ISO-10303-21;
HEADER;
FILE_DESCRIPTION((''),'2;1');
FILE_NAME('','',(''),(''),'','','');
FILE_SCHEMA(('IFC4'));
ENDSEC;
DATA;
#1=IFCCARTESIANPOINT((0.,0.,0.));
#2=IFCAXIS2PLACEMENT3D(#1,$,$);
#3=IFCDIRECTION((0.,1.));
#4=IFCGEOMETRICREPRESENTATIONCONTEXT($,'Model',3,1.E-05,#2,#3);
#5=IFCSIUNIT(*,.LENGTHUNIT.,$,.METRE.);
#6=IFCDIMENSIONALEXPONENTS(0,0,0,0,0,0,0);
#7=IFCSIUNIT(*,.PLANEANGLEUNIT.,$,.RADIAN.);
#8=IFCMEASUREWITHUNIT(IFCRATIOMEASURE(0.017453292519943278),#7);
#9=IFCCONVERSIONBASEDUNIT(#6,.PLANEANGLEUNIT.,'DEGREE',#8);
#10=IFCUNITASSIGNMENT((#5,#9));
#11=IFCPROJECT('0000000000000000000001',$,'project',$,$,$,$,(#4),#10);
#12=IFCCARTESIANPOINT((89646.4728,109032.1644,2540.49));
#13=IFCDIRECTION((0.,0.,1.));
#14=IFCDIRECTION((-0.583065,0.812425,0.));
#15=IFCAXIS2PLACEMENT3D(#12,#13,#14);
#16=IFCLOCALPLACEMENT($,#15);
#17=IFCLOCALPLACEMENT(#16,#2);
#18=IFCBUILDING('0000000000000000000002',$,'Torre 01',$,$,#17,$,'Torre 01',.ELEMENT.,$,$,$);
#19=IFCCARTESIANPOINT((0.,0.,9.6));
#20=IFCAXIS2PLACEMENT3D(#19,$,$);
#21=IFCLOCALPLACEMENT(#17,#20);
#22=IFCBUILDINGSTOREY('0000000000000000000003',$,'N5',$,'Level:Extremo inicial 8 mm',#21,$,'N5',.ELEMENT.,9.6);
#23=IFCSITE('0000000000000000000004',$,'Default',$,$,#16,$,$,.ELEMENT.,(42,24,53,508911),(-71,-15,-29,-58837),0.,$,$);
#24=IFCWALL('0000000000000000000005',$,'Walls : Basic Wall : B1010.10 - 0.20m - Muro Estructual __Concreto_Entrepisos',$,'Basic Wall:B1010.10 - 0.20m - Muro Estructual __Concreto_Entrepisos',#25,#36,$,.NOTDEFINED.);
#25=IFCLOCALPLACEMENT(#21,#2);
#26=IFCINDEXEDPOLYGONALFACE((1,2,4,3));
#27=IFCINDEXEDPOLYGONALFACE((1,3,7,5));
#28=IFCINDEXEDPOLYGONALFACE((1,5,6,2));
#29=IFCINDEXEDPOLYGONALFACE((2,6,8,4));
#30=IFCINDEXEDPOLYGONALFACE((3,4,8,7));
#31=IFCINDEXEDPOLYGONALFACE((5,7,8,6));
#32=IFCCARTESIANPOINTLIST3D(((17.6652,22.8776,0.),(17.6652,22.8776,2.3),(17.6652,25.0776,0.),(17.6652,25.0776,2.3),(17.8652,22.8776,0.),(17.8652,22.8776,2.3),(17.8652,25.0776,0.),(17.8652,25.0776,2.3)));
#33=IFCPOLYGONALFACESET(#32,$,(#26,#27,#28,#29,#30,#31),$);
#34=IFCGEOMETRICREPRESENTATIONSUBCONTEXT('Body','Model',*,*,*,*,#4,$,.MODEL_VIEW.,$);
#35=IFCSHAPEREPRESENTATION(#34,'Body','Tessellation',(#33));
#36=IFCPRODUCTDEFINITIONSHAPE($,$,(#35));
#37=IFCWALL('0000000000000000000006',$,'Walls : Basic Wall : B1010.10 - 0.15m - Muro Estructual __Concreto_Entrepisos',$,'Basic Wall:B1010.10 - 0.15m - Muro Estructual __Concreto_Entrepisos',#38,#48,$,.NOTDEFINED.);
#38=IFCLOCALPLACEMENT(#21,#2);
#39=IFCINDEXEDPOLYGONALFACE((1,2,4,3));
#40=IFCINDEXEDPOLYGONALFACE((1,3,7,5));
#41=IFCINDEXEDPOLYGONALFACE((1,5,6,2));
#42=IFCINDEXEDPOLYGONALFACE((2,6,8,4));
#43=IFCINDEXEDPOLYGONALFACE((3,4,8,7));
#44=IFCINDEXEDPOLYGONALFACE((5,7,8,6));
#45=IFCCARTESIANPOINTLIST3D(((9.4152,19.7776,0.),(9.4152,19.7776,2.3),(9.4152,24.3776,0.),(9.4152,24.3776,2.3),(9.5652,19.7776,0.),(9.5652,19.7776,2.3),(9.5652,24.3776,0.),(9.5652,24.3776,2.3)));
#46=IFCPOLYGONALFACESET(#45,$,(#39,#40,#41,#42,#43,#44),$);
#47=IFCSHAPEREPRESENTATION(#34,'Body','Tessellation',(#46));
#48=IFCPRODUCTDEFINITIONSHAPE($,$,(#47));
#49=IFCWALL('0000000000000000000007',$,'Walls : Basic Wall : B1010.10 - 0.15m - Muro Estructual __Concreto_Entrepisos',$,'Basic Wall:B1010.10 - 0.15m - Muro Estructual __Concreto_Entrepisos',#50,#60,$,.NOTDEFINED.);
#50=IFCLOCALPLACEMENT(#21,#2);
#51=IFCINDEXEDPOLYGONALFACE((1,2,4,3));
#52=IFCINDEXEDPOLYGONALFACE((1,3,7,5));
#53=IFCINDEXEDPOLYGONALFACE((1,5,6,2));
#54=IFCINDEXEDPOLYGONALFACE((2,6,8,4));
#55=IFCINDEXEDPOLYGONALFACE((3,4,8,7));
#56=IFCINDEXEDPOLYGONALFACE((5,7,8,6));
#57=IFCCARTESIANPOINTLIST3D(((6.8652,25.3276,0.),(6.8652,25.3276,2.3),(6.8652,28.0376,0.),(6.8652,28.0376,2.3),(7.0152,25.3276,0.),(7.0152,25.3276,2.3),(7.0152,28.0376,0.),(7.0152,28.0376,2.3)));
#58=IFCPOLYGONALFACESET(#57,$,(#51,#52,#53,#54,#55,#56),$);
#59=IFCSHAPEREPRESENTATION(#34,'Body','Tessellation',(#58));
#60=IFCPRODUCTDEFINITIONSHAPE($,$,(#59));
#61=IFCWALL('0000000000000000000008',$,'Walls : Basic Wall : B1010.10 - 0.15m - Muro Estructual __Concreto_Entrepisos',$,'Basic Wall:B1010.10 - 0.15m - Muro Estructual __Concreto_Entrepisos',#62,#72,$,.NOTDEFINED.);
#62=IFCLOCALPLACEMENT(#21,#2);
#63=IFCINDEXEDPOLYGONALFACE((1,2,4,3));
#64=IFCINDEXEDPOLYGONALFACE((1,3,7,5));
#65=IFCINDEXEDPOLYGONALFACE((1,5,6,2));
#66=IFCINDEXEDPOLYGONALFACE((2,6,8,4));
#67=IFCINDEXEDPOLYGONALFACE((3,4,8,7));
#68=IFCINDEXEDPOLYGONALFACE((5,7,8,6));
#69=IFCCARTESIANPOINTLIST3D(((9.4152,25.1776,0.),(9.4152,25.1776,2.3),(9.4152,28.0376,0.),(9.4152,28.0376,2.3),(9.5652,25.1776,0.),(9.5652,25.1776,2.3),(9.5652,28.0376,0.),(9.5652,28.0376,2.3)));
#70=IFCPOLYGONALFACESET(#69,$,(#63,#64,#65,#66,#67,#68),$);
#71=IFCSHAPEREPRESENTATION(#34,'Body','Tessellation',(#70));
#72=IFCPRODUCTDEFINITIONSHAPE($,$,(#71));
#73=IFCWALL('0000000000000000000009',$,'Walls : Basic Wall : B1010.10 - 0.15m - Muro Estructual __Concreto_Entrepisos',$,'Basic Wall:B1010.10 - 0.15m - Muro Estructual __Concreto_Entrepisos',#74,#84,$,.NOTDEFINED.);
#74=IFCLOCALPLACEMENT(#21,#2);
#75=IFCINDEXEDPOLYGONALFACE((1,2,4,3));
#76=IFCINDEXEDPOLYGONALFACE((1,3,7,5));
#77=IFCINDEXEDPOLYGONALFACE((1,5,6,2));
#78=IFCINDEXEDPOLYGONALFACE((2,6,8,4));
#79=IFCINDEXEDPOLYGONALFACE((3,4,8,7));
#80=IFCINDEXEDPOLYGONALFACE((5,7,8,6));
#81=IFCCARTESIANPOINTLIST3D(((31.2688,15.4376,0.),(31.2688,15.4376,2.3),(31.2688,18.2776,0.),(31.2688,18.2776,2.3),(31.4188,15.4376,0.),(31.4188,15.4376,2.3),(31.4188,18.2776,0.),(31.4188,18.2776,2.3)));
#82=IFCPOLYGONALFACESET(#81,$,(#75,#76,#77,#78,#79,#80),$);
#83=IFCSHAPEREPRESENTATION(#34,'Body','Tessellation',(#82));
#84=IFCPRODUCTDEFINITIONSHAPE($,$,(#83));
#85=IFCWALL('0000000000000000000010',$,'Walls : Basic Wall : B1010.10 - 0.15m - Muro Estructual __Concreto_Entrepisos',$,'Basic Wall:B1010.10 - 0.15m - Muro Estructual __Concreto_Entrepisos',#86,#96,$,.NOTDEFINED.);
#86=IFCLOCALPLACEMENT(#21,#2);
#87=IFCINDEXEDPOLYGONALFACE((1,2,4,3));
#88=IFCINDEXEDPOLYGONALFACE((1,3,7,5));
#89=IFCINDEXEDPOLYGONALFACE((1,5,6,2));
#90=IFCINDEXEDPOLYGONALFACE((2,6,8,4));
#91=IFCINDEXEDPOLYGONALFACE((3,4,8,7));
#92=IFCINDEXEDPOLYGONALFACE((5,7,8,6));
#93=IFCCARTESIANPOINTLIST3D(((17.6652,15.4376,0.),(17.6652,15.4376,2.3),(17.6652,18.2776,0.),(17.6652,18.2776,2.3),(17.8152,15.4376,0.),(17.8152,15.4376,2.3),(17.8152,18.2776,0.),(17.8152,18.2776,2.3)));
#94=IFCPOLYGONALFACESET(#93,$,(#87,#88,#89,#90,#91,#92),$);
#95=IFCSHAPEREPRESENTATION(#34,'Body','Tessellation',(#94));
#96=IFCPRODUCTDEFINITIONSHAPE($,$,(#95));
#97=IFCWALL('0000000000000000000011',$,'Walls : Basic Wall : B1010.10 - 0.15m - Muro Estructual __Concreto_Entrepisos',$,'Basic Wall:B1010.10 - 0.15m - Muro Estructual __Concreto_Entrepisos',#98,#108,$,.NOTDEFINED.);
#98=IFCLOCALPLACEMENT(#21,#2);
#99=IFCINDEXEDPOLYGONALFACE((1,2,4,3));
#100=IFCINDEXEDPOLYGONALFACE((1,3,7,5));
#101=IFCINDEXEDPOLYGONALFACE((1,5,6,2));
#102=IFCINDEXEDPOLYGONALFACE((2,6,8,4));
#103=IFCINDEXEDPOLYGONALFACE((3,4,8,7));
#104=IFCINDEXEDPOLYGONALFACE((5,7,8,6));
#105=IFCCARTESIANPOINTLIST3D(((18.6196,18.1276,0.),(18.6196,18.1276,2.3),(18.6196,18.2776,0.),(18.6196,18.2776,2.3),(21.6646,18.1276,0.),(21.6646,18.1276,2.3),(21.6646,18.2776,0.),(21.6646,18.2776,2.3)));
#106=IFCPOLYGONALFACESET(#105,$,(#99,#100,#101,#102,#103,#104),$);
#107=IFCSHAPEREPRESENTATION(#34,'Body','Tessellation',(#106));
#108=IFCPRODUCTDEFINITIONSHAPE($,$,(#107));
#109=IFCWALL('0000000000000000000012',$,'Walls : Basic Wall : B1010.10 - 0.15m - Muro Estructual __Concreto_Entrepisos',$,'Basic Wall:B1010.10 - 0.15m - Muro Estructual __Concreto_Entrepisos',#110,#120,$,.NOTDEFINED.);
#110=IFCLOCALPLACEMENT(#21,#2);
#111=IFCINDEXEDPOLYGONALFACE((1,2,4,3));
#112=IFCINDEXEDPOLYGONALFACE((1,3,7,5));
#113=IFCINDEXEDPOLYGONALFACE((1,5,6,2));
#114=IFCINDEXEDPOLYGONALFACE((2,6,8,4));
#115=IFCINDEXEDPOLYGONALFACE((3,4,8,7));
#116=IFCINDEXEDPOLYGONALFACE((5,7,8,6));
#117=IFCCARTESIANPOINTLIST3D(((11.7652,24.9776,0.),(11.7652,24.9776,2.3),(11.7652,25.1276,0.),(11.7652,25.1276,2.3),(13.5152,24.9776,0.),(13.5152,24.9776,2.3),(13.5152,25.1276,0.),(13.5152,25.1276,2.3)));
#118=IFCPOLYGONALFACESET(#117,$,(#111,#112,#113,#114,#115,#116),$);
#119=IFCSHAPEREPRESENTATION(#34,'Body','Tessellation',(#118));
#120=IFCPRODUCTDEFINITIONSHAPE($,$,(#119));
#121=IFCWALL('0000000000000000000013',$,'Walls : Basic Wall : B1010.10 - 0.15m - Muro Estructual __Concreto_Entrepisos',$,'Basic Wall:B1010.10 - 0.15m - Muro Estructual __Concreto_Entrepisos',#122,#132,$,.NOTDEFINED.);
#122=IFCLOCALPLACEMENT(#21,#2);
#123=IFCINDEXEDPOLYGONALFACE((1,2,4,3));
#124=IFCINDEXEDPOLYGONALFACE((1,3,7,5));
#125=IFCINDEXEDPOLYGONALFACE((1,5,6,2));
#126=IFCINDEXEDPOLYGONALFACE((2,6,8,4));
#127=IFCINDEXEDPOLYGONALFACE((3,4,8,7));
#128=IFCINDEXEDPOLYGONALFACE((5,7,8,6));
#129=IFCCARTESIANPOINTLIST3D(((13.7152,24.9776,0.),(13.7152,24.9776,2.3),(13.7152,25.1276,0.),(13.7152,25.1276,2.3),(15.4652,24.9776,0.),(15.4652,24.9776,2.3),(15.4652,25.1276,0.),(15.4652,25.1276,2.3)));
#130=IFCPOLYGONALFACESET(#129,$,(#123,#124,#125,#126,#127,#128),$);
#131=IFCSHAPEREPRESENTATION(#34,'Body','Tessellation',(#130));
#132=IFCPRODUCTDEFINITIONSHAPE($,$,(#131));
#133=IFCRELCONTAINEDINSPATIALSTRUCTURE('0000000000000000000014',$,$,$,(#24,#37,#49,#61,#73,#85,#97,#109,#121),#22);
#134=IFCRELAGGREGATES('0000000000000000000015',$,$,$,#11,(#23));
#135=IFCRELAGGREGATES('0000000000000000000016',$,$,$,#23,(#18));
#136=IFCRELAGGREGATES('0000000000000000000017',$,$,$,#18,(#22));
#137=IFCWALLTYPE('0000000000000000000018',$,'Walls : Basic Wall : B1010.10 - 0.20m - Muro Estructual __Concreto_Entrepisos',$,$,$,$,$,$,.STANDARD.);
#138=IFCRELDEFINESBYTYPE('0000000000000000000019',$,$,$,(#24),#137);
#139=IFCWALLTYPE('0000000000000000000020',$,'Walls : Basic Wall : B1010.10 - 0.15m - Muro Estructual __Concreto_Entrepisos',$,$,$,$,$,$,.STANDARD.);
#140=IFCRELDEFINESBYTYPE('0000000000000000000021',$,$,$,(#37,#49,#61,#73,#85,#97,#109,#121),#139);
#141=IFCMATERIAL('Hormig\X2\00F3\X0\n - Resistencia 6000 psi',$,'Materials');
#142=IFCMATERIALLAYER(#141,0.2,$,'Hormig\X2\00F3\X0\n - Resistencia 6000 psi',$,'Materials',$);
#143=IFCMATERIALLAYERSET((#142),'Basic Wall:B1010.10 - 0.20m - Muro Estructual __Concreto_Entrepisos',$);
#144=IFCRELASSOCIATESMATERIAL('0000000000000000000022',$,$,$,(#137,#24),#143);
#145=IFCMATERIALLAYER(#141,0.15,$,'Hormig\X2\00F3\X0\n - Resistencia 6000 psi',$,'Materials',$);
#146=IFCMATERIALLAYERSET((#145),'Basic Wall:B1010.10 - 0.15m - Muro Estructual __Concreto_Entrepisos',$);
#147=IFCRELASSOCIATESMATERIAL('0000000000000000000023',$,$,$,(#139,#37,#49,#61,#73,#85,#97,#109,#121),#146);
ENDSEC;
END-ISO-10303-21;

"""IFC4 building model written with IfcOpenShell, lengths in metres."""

from ifc_helpers import new_model, entity, si_unit, converted_unit, direction, frame, frame_2d, origin, place, context, subcontext, project, spatial, rectangle, extrude, material, layer, layer_set, layer_usage, type_object, element, save


model = new_model("IFC4")

# Units and contexts
model_context = context("Model", 3, precision=1e-05, world=origin(), true_north=direction((0.0, 1.0)))
body_context = subcontext(model_context, "Body", "Model", "MODEL_VIEW")
ifc_project = project(units=[si_unit("LENGTHUNIT", "METRE"), converted_unit("PLANEANGLEUNIT", "DEGREE", entity("IfcRatioMeasure", 0.017453292519943278), si_unit("PLANEANGLEUNIT", "RADIAN"), dimensions=[0, 0, 0, 0, 0, 0, 0])], contexts=[model_context])

# Site, building, storey
site_placement = place(None, frame((89646.4728, 109032.1644, 2540.49), z_axis=(0.0, 0.0, 1.0), x_axis=(-0.583065, 0.812425, 0.0)))
site = spatial("IfcSite", under=ifc_project, at=site_placement, Name="Default", CompositionType="ELEMENT", RefLatitude=(42, 24, 53, 508911), RefLongitude=(-71, -15, -29, -58837), RefElevation=0.0)
building_placement = place(site_placement, origin())
building = spatial("IfcBuilding", under=site, at=building_placement, Name="Torre 01", LongName="Torre 01", CompositionType="ELEMENT")
storey_placement = place(building_placement, frame((0.0, 0.0, 9.6)))
storey = spatial("IfcBuildingStorey", under=building, at=storey_placement, Name="N5", ObjectType="Level:Extremo inicial 8 mm", LongName="N5", CompositionType="ELEMENT", Elevation=9.6)

# Walls
ifc_material = material(Name="Hormigón - Resistencia 6000 psi", Category="Materials")
ifc_layer_1 = layer(ifc_material, 0.2, Name="Hormigón - Resistencia 6000 psi", Category="Materials")
ifc_layer_set_1 = layer_set([ifc_layer_1], Name="Basic Wall:B1010.10 - 0.20m - Muro Estructual __Concreto_Entrepisos")
wall_type_1 = type_object("IfcWallType", Name="Walls : Basic Wall : B1010.10 - 0.20m - Muro Estructual __Concreto_Entrepisos", PredefinedType="STANDARD", material=ifc_layer_set_1)
ifc_layer_usage_1 = layer_usage(ifc_layer_set_1, "AXIS2", "NEGATIVE", 0.1)
wall_1_placement = place(storey_placement, frame((17.7652, 22.8776, 0.0), z_axis=(0.0, 0.0, 1.0), x_axis=(0.0, 1.0, 0.0)))
element("IfcWall", 1, at=wall_1_placement, inside=storey, type_object=wall_type_1, material=ifc_layer_usage_1, Name="Walls : Basic Wall : B1010.10 - 0.20m - Muro Estructual __Concreto_Entrepisos", ObjectType="Basic Wall:B1010.10 - 0.20m - Muro Estructual __Concreto_Entrepisos", PredefinedType="NOTDEFINED", context=body_context, shape_type="SweptSolid", body=[
    extrude(rectangle(XDim=2.2, YDim=0.2, at=frame_2d((1.1, 0.0), x_axis=(-1.0, 0.0))), origin(), (0.0, 0.0, 1.0), 2.3),
])
ifc_layer_2 = layer(ifc_material, 0.15, Name="Hormigón - Resistencia 6000 psi", Category="Materials")
ifc_layer_set_2 = layer_set([ifc_layer_2], Name="Basic Wall:B1010.10 - 0.15m - Muro Estructual __Concreto_Entrepisos")
ifc_layer_usage_2 = layer_usage(ifc_layer_set_2, "AXIS2", "NEGATIVE", 0.075)
wall_type_2 = type_object("IfcWallType", Name="Walls : Basic Wall : B1010.10 - 0.15m - Muro Estructual __Concreto_Entrepisos", PredefinedType="STANDARD", material=ifc_layer_set_2)
wall_2_placement = place(storey_placement, frame((9.4902, 24.3776, 0.0), z_axis=(0.0, 0.0, 1.0), x_axis=(0.0, -1.0, 0.0)))
element("IfcWall", 2, at=wall_2_placement, inside=storey, type_object=wall_type_2, material=ifc_layer_usage_2, Name="Walls : Basic Wall : B1010.10 - 0.15m - Muro Estructual __Concreto_Entrepisos", ObjectType="Basic Wall:B1010.10 - 0.15m - Muro Estructual __Concreto_Entrepisos", PredefinedType="NOTDEFINED", context=body_context, shape_type="SweptSolid", body=[
    extrude(rectangle(XDim=4.6, YDim=0.15, at=frame_2d((2.3, 0.0), x_axis=(-1.0, 0.0))), origin(), (0.0, 0.0, 1.0), 2.3),
])
ifc_layer_usage_3 = layer_usage(ifc_layer_set_2, "AXIS2", "NEGATIVE", 0.075)
wall_3_placement = place(storey_placement, frame((6.9402, 25.3276, 0.0), z_axis=(0.0, 0.0, 1.0), x_axis=(0.0, 1.0, 0.0)))
element("IfcWall", 3, at=wall_3_placement, inside=storey, type_object=wall_type_2, material=ifc_layer_usage_3, Name="Walls : Basic Wall : B1010.10 - 0.15m - Muro Estructual __Concreto_Entrepisos", ObjectType="Basic Wall:B1010.10 - 0.15m - Muro Estructual __Concreto_Entrepisos", PredefinedType="NOTDEFINED", context=body_context, shape_type="SweptSolid", body=[
    extrude(rectangle(XDim=2.71, YDim=0.15, at=frame_2d((1.355, 0.0), x_axis=(-1.0, 0.0))), origin(), (0.0, 0.0, 1.0), 2.3),
])
ifc_layer_usage_4 = layer_usage(ifc_layer_set_2, "AXIS2", "NEGATIVE", 0.075)
wall_4_placement = place(storey_placement, frame((9.4902, 28.0376, 0.0), z_axis=(0.0, 0.0, 1.0), x_axis=(0.0, -1.0, 0.0)))
element("IfcWall", 4, at=wall_4_placement, inside=storey, type_object=wall_type_2, material=ifc_layer_usage_4, Name="Walls : Basic Wall : B1010.10 - 0.15m - Muro Estructual __Concreto_Entrepisos", ObjectType="Basic Wall:B1010.10 - 0.15m - Muro Estructual __Concreto_Entrepisos", PredefinedType="NOTDEFINED", context=body_context, shape_type="SweptSolid", body=[
    extrude(rectangle(XDim=2.86, YDim=0.15, at=frame_2d((1.43, 0.0), x_axis=(-1.0, 0.0))), origin(), (0.0, 0.0, 1.0), 2.3),
])
ifc_layer_usage_5 = layer_usage(ifc_layer_set_2, "AXIS2", "NEGATIVE", 0.075)
wall_5_placement = place(storey_placement, frame((31.3438, 15.4376, 0.0), z_axis=(0.0, 0.0, 1.0), x_axis=(0.0, 1.0, 0.0)))
element("IfcWall", 5, at=wall_5_placement, inside=storey, type_object=wall_type_2, material=ifc_layer_usage_5, Name="Walls : Basic Wall : B1010.10 - 0.15m - Muro Estructual __Concreto_Entrepisos", ObjectType="Basic Wall:B1010.10 - 0.15m - Muro Estructual __Concreto_Entrepisos", PredefinedType="NOTDEFINED", context=body_context, shape_type="SweptSolid", body=[
    extrude(rectangle(XDim=2.84, YDim=0.15, at=frame_2d((1.42, 0.0), x_axis=(-1.0, 0.0))), origin(), (0.0, 0.0, 1.0), 2.3),
])
ifc_layer_usage_6 = layer_usage(ifc_layer_set_2, "AXIS2", "NEGATIVE", 0.075)
wall_6_placement = place(storey_placement, frame((17.7402, 18.2776, 0.0), z_axis=(0.0, 0.0, 1.0), x_axis=(0.0, -1.0, 0.0)))
element("IfcWall", 6, at=wall_6_placement, inside=storey, type_object=wall_type_2, material=ifc_layer_usage_6, Name="Walls : Basic Wall : B1010.10 - 0.15m - Muro Estructual __Concreto_Entrepisos", ObjectType="Basic Wall:B1010.10 - 0.15m - Muro Estructual __Concreto_Entrepisos", PredefinedType="NOTDEFINED", context=body_context, shape_type="SweptSolid", body=[
    extrude(rectangle(XDim=2.84, YDim=0.15, at=frame_2d((1.42, 0.0), x_axis=(-1.0, 0.0))), origin(), (0.0, 0.0, 1.0), 2.3),
])
ifc_layer_usage_7 = layer_usage(ifc_layer_set_2, "AXIS2", "NEGATIVE", 0.075)
wall_7_placement = place(storey_placement, frame((18.6196, 18.2026, 0.0)))
element("IfcWall", 7, at=wall_7_placement, inside=storey, type_object=wall_type_2, material=ifc_layer_usage_7, Name="Walls : Basic Wall : B1010.10 - 0.15m - Muro Estructual __Concreto_Entrepisos", ObjectType="Basic Wall:B1010.10 - 0.15m - Muro Estructual __Concreto_Entrepisos", PredefinedType="NOTDEFINED", context=body_context, shape_type="SweptSolid", body=[
    extrude(rectangle(XDim=3.045, YDim=0.15, at=frame_2d((1.5225, 0.0), x_axis=(-1.0, 0.0))), origin(), (0.0, 0.0, 1.0), 2.3),
])
ifc_layer_usage_8 = layer_usage(ifc_layer_set_2, "AXIS2", "POSITIVE", -0.075)
wall_8_placement = place(storey_placement, frame((11.7652, 25.0526, 0.0)))
element("IfcWall", 8, at=wall_8_placement, inside=storey, type_object=wall_type_2, material=ifc_layer_usage_8, Name="Walls : Basic Wall : B1010.10 - 0.15m - Muro Estructual __Concreto_Entrepisos", ObjectType="Basic Wall:B1010.10 - 0.15m - Muro Estructual __Concreto_Entrepisos", PredefinedType="NOTDEFINED", context=body_context, shape_type="SweptSolid", body=[
    extrude(rectangle(XDim=1.75, YDim=0.15, at=frame_2d((0.875, 0.0), x_axis=(-1.0, 0.0))), origin(), (0.0, 0.0, 1.0), 2.3),
])
ifc_layer_usage_9 = layer_usage(ifc_layer_set_2, "AXIS2", "POSITIVE", -0.075)
wall_9_placement = place(storey_placement, frame((13.7152, 25.0526, 0.0)))
element("IfcWall", 9, at=wall_9_placement, inside=storey, type_object=wall_type_2, material=ifc_layer_usage_9, Name="Walls : Basic Wall : B1010.10 - 0.15m - Muro Estructual __Concreto_Entrepisos", ObjectType="Basic Wall:B1010.10 - 0.15m - Muro Estructual __Concreto_Entrepisos", PredefinedType="NOTDEFINED", context=body_context, shape_type="SweptSolid", body=[
    extrude(rectangle(XDim=1.75, YDim=0.15, at=frame_2d((0.875, 0.0), x_axis=(-1.0, 0.0))), origin(), (0.0, 0.0, 1.0), 2.3),
])

save(model, "model.ifc")
